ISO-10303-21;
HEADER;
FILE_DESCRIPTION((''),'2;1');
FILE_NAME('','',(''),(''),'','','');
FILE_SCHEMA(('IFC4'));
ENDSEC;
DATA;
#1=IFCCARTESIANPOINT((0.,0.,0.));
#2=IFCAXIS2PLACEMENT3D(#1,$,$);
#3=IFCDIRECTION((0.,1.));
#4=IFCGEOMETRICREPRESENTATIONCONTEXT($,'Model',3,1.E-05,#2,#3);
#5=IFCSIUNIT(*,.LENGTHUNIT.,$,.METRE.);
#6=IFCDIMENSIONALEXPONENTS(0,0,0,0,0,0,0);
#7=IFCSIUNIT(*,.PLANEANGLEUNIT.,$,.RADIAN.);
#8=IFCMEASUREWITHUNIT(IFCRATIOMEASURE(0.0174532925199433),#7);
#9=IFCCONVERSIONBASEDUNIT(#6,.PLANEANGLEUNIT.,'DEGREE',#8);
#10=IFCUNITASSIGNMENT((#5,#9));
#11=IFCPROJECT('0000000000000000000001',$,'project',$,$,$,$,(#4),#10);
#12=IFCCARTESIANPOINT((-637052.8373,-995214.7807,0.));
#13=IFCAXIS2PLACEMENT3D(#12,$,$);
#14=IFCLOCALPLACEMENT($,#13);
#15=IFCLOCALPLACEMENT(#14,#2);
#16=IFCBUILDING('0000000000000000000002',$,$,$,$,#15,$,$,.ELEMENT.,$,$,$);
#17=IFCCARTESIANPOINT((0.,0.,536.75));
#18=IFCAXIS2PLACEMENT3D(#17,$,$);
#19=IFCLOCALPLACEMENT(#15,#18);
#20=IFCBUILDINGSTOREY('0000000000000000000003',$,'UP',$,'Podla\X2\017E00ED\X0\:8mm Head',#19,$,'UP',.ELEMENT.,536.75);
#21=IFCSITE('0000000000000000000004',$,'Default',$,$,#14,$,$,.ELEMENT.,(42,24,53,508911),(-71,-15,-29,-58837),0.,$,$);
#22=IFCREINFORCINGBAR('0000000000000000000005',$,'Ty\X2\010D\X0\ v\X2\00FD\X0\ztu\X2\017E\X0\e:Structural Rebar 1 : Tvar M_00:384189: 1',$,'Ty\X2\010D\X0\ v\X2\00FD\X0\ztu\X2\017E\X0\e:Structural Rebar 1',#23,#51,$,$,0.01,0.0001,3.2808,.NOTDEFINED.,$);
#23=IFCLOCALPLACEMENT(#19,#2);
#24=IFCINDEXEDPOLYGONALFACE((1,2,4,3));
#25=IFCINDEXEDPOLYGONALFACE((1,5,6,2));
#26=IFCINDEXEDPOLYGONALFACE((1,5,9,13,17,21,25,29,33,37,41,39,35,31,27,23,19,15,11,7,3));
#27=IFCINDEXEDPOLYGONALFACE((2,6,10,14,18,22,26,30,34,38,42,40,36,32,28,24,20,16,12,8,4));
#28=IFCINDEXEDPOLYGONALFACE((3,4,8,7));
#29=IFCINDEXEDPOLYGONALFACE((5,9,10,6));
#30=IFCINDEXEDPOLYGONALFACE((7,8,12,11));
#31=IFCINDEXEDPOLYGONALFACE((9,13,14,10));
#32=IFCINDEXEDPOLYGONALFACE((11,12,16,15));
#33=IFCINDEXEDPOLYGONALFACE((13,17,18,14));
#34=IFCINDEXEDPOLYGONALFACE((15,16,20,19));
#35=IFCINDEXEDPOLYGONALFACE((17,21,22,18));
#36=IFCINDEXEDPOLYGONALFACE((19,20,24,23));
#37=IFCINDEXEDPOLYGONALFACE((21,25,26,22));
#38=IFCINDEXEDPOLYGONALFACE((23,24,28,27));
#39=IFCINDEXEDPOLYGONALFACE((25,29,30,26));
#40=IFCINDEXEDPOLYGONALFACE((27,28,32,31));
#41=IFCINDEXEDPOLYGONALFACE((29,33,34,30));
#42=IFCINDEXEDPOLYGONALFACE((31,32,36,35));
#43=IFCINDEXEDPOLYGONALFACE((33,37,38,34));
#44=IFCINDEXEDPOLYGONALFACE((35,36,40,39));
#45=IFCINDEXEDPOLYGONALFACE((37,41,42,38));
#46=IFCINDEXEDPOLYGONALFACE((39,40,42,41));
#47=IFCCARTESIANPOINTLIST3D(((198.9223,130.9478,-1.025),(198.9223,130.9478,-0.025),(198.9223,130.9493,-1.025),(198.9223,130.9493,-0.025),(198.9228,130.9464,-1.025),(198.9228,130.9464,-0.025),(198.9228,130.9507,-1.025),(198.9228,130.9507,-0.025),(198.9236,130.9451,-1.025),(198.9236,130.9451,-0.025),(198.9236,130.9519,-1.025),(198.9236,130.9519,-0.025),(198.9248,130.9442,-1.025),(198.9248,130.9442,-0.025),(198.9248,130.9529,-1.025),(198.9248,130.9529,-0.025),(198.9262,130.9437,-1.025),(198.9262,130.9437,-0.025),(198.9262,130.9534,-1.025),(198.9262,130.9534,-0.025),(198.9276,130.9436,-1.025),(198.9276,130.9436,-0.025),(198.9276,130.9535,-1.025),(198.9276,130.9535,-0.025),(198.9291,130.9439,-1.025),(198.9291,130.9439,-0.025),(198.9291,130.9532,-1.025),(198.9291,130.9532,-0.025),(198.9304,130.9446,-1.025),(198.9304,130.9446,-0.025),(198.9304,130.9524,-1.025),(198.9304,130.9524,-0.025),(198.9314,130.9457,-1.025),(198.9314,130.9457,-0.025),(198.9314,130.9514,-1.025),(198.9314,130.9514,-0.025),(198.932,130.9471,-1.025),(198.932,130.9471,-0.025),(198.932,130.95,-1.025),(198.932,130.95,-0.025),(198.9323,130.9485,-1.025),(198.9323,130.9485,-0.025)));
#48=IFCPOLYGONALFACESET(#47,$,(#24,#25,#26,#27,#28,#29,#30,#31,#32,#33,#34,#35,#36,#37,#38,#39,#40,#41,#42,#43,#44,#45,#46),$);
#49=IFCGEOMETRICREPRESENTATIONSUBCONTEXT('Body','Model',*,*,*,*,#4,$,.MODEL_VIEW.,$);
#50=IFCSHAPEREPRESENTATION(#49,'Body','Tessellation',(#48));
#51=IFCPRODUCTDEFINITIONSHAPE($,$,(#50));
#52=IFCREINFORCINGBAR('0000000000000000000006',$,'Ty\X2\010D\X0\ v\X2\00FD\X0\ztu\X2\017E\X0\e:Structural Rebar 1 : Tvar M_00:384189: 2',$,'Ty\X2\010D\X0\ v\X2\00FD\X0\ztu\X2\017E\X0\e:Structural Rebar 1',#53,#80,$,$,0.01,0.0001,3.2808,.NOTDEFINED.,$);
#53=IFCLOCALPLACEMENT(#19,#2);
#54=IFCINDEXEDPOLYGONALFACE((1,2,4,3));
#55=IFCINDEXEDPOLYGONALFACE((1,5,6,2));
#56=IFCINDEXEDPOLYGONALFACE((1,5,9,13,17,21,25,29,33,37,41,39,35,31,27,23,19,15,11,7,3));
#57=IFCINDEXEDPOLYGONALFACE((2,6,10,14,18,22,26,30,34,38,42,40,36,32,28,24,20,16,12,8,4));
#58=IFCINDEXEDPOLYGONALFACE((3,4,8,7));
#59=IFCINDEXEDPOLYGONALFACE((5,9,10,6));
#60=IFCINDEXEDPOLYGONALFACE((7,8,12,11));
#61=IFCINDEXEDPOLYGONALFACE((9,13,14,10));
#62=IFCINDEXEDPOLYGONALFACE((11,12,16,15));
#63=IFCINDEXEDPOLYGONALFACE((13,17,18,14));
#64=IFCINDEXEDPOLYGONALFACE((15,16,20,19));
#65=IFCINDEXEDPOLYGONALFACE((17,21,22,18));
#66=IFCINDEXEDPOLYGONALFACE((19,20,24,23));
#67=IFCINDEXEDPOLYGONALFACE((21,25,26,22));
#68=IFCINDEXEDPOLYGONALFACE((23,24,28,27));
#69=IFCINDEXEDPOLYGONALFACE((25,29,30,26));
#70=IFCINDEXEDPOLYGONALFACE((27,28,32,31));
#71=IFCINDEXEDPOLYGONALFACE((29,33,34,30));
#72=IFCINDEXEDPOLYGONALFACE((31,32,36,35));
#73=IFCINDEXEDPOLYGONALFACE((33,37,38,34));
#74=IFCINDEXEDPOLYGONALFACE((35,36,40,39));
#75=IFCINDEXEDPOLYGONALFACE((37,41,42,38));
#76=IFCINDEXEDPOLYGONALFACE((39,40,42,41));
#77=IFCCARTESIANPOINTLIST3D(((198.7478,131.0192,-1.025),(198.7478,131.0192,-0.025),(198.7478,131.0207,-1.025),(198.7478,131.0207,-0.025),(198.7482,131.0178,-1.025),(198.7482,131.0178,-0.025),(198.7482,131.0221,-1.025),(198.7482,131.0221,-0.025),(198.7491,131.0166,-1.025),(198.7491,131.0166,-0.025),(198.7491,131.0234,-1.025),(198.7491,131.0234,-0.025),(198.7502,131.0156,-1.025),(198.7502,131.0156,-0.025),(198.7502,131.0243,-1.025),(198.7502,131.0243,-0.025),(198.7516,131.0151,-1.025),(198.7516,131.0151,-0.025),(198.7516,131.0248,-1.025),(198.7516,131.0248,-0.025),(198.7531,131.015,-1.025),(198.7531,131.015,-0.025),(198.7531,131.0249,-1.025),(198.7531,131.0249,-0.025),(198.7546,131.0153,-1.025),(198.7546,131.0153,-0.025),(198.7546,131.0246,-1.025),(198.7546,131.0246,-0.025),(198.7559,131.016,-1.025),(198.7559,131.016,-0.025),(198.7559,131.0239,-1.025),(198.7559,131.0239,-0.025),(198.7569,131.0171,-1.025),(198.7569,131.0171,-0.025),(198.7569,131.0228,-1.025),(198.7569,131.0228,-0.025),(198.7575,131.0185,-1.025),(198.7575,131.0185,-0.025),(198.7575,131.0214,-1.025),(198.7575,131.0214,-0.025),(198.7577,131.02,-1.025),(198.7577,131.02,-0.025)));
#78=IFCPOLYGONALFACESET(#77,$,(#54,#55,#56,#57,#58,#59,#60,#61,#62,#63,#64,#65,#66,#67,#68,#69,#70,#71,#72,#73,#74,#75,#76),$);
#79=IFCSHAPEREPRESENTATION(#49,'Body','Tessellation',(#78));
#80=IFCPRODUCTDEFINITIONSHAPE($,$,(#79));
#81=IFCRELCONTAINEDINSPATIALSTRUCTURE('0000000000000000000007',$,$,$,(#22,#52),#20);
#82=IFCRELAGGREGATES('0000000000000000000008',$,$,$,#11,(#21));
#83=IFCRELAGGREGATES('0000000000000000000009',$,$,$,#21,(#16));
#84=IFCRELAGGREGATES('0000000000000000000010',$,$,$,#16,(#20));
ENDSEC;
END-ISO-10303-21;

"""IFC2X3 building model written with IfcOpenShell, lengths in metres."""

from ifc_helpers import new_model, entity, si_unit, converted_unit, direction, frame, origin, place, context, subcontext, project, spatial, element, save


model = new_model("IFC2X3")

# Units and contexts
model_context = context("Model", 3, precision=1e-05, world=origin(), true_north=direction((0.0, 1.0)))
body_context = subcontext(model_context, "Body", "Model", "MODEL_VIEW")
ifc_project = project(units=[si_unit("LENGTHUNIT", "METRE"), converted_unit("PLANEANGLEUNIT", "DEGREE", entity("IfcRatioMeasure", 0.0174532925199433), si_unit("PLANEANGLEUNIT", "RADIAN"), dimensions=[0, 0, 0, 0, 0, 0, 0])], contexts=[model_context])

# Site, building, storey
site_placement = place(None, frame((-637052.8373, -995214.7807, 0.0)))
site = spatial("IfcSite", under=ifc_project, at=site_placement, Name="Default", CompositionType="ELEMENT", RefLatitude=(42, 24, 53, 508911), RefLongitude=(-71, -15, -29, -58837), RefElevation=0.0)
building_placement = place(site_placement, origin())
building = spatial("IfcBuilding", under=site, at=building_placement, CompositionType="ELEMENT")
storey_placement = place(building_placement, frame((0.0, 0.0, 536.75)))
storey = spatial("IfcBuildingStorey", under=building, at=storey_placement, Name="UP", ObjectType="Podlaží:8mm Head", LongName="UP", CompositionType="ELEMENT", Elevation=536.75)

# Reinforcing bars
reinforcing_bar_1_placement = place(storey_placement, origin())
element("IfcReinforcingBar", 1, at=reinforcing_bar_1_placement, inside=storey, Name="Tyč výztuže:Structural Rebar 1 : Tvar M_00:384189: 1", ObjectType="Tyč výztuže:Structural Rebar 1", BarLength=3.2808, BarRole="NOTDEFINED", CrossSectionArea=0.0001, NominalDiameter=0.01, context=body_context, shape_type="AdvancedSweptSolid", body=[
    entity("IfcSweptDiskSolid", entity("IfcCompositeCurve", [entity("IfcCompositeCurveSegment", "CONTINUOUS", True, entity("IfcPolyline", [entity("IfcCartesianPoint", [-198.9273, -130.9485, 0.025]), entity("IfcCartesianPoint", [-198.9273, -130.9485, 1.025])]))], False), 0.005, None, 0.0, 1.0),
])
reinforcing_bar_2_placement = place(storey_placement, origin())
element("IfcReinforcingBar", 2, at=reinforcing_bar_2_placement, inside=storey, Name="Tyč výztuže:Structural Rebar 1 : Tvar M_00:384189: 2", ObjectType="Tyč výztuže:Structural Rebar 1", BarLength=3.2808, BarRole="NOTDEFINED", CrossSectionArea=0.0001, NominalDiameter=0.01, context=body_context, shape_type="AdvancedSweptSolid", body=[
    entity("IfcSweptDiskSolid", entity("IfcCompositeCurve", [entity("IfcCompositeCurveSegment", "CONTINUOUS", True, entity("IfcPolyline", [entity("IfcCartesianPoint", [-198.7527, -131.02, 0.025]), entity("IfcCartesianPoint", [-198.7527, -131.02, 1.025])]))], False), 0.005, None, 0.0, 1.0),
])

save(model, "model.ifc")
